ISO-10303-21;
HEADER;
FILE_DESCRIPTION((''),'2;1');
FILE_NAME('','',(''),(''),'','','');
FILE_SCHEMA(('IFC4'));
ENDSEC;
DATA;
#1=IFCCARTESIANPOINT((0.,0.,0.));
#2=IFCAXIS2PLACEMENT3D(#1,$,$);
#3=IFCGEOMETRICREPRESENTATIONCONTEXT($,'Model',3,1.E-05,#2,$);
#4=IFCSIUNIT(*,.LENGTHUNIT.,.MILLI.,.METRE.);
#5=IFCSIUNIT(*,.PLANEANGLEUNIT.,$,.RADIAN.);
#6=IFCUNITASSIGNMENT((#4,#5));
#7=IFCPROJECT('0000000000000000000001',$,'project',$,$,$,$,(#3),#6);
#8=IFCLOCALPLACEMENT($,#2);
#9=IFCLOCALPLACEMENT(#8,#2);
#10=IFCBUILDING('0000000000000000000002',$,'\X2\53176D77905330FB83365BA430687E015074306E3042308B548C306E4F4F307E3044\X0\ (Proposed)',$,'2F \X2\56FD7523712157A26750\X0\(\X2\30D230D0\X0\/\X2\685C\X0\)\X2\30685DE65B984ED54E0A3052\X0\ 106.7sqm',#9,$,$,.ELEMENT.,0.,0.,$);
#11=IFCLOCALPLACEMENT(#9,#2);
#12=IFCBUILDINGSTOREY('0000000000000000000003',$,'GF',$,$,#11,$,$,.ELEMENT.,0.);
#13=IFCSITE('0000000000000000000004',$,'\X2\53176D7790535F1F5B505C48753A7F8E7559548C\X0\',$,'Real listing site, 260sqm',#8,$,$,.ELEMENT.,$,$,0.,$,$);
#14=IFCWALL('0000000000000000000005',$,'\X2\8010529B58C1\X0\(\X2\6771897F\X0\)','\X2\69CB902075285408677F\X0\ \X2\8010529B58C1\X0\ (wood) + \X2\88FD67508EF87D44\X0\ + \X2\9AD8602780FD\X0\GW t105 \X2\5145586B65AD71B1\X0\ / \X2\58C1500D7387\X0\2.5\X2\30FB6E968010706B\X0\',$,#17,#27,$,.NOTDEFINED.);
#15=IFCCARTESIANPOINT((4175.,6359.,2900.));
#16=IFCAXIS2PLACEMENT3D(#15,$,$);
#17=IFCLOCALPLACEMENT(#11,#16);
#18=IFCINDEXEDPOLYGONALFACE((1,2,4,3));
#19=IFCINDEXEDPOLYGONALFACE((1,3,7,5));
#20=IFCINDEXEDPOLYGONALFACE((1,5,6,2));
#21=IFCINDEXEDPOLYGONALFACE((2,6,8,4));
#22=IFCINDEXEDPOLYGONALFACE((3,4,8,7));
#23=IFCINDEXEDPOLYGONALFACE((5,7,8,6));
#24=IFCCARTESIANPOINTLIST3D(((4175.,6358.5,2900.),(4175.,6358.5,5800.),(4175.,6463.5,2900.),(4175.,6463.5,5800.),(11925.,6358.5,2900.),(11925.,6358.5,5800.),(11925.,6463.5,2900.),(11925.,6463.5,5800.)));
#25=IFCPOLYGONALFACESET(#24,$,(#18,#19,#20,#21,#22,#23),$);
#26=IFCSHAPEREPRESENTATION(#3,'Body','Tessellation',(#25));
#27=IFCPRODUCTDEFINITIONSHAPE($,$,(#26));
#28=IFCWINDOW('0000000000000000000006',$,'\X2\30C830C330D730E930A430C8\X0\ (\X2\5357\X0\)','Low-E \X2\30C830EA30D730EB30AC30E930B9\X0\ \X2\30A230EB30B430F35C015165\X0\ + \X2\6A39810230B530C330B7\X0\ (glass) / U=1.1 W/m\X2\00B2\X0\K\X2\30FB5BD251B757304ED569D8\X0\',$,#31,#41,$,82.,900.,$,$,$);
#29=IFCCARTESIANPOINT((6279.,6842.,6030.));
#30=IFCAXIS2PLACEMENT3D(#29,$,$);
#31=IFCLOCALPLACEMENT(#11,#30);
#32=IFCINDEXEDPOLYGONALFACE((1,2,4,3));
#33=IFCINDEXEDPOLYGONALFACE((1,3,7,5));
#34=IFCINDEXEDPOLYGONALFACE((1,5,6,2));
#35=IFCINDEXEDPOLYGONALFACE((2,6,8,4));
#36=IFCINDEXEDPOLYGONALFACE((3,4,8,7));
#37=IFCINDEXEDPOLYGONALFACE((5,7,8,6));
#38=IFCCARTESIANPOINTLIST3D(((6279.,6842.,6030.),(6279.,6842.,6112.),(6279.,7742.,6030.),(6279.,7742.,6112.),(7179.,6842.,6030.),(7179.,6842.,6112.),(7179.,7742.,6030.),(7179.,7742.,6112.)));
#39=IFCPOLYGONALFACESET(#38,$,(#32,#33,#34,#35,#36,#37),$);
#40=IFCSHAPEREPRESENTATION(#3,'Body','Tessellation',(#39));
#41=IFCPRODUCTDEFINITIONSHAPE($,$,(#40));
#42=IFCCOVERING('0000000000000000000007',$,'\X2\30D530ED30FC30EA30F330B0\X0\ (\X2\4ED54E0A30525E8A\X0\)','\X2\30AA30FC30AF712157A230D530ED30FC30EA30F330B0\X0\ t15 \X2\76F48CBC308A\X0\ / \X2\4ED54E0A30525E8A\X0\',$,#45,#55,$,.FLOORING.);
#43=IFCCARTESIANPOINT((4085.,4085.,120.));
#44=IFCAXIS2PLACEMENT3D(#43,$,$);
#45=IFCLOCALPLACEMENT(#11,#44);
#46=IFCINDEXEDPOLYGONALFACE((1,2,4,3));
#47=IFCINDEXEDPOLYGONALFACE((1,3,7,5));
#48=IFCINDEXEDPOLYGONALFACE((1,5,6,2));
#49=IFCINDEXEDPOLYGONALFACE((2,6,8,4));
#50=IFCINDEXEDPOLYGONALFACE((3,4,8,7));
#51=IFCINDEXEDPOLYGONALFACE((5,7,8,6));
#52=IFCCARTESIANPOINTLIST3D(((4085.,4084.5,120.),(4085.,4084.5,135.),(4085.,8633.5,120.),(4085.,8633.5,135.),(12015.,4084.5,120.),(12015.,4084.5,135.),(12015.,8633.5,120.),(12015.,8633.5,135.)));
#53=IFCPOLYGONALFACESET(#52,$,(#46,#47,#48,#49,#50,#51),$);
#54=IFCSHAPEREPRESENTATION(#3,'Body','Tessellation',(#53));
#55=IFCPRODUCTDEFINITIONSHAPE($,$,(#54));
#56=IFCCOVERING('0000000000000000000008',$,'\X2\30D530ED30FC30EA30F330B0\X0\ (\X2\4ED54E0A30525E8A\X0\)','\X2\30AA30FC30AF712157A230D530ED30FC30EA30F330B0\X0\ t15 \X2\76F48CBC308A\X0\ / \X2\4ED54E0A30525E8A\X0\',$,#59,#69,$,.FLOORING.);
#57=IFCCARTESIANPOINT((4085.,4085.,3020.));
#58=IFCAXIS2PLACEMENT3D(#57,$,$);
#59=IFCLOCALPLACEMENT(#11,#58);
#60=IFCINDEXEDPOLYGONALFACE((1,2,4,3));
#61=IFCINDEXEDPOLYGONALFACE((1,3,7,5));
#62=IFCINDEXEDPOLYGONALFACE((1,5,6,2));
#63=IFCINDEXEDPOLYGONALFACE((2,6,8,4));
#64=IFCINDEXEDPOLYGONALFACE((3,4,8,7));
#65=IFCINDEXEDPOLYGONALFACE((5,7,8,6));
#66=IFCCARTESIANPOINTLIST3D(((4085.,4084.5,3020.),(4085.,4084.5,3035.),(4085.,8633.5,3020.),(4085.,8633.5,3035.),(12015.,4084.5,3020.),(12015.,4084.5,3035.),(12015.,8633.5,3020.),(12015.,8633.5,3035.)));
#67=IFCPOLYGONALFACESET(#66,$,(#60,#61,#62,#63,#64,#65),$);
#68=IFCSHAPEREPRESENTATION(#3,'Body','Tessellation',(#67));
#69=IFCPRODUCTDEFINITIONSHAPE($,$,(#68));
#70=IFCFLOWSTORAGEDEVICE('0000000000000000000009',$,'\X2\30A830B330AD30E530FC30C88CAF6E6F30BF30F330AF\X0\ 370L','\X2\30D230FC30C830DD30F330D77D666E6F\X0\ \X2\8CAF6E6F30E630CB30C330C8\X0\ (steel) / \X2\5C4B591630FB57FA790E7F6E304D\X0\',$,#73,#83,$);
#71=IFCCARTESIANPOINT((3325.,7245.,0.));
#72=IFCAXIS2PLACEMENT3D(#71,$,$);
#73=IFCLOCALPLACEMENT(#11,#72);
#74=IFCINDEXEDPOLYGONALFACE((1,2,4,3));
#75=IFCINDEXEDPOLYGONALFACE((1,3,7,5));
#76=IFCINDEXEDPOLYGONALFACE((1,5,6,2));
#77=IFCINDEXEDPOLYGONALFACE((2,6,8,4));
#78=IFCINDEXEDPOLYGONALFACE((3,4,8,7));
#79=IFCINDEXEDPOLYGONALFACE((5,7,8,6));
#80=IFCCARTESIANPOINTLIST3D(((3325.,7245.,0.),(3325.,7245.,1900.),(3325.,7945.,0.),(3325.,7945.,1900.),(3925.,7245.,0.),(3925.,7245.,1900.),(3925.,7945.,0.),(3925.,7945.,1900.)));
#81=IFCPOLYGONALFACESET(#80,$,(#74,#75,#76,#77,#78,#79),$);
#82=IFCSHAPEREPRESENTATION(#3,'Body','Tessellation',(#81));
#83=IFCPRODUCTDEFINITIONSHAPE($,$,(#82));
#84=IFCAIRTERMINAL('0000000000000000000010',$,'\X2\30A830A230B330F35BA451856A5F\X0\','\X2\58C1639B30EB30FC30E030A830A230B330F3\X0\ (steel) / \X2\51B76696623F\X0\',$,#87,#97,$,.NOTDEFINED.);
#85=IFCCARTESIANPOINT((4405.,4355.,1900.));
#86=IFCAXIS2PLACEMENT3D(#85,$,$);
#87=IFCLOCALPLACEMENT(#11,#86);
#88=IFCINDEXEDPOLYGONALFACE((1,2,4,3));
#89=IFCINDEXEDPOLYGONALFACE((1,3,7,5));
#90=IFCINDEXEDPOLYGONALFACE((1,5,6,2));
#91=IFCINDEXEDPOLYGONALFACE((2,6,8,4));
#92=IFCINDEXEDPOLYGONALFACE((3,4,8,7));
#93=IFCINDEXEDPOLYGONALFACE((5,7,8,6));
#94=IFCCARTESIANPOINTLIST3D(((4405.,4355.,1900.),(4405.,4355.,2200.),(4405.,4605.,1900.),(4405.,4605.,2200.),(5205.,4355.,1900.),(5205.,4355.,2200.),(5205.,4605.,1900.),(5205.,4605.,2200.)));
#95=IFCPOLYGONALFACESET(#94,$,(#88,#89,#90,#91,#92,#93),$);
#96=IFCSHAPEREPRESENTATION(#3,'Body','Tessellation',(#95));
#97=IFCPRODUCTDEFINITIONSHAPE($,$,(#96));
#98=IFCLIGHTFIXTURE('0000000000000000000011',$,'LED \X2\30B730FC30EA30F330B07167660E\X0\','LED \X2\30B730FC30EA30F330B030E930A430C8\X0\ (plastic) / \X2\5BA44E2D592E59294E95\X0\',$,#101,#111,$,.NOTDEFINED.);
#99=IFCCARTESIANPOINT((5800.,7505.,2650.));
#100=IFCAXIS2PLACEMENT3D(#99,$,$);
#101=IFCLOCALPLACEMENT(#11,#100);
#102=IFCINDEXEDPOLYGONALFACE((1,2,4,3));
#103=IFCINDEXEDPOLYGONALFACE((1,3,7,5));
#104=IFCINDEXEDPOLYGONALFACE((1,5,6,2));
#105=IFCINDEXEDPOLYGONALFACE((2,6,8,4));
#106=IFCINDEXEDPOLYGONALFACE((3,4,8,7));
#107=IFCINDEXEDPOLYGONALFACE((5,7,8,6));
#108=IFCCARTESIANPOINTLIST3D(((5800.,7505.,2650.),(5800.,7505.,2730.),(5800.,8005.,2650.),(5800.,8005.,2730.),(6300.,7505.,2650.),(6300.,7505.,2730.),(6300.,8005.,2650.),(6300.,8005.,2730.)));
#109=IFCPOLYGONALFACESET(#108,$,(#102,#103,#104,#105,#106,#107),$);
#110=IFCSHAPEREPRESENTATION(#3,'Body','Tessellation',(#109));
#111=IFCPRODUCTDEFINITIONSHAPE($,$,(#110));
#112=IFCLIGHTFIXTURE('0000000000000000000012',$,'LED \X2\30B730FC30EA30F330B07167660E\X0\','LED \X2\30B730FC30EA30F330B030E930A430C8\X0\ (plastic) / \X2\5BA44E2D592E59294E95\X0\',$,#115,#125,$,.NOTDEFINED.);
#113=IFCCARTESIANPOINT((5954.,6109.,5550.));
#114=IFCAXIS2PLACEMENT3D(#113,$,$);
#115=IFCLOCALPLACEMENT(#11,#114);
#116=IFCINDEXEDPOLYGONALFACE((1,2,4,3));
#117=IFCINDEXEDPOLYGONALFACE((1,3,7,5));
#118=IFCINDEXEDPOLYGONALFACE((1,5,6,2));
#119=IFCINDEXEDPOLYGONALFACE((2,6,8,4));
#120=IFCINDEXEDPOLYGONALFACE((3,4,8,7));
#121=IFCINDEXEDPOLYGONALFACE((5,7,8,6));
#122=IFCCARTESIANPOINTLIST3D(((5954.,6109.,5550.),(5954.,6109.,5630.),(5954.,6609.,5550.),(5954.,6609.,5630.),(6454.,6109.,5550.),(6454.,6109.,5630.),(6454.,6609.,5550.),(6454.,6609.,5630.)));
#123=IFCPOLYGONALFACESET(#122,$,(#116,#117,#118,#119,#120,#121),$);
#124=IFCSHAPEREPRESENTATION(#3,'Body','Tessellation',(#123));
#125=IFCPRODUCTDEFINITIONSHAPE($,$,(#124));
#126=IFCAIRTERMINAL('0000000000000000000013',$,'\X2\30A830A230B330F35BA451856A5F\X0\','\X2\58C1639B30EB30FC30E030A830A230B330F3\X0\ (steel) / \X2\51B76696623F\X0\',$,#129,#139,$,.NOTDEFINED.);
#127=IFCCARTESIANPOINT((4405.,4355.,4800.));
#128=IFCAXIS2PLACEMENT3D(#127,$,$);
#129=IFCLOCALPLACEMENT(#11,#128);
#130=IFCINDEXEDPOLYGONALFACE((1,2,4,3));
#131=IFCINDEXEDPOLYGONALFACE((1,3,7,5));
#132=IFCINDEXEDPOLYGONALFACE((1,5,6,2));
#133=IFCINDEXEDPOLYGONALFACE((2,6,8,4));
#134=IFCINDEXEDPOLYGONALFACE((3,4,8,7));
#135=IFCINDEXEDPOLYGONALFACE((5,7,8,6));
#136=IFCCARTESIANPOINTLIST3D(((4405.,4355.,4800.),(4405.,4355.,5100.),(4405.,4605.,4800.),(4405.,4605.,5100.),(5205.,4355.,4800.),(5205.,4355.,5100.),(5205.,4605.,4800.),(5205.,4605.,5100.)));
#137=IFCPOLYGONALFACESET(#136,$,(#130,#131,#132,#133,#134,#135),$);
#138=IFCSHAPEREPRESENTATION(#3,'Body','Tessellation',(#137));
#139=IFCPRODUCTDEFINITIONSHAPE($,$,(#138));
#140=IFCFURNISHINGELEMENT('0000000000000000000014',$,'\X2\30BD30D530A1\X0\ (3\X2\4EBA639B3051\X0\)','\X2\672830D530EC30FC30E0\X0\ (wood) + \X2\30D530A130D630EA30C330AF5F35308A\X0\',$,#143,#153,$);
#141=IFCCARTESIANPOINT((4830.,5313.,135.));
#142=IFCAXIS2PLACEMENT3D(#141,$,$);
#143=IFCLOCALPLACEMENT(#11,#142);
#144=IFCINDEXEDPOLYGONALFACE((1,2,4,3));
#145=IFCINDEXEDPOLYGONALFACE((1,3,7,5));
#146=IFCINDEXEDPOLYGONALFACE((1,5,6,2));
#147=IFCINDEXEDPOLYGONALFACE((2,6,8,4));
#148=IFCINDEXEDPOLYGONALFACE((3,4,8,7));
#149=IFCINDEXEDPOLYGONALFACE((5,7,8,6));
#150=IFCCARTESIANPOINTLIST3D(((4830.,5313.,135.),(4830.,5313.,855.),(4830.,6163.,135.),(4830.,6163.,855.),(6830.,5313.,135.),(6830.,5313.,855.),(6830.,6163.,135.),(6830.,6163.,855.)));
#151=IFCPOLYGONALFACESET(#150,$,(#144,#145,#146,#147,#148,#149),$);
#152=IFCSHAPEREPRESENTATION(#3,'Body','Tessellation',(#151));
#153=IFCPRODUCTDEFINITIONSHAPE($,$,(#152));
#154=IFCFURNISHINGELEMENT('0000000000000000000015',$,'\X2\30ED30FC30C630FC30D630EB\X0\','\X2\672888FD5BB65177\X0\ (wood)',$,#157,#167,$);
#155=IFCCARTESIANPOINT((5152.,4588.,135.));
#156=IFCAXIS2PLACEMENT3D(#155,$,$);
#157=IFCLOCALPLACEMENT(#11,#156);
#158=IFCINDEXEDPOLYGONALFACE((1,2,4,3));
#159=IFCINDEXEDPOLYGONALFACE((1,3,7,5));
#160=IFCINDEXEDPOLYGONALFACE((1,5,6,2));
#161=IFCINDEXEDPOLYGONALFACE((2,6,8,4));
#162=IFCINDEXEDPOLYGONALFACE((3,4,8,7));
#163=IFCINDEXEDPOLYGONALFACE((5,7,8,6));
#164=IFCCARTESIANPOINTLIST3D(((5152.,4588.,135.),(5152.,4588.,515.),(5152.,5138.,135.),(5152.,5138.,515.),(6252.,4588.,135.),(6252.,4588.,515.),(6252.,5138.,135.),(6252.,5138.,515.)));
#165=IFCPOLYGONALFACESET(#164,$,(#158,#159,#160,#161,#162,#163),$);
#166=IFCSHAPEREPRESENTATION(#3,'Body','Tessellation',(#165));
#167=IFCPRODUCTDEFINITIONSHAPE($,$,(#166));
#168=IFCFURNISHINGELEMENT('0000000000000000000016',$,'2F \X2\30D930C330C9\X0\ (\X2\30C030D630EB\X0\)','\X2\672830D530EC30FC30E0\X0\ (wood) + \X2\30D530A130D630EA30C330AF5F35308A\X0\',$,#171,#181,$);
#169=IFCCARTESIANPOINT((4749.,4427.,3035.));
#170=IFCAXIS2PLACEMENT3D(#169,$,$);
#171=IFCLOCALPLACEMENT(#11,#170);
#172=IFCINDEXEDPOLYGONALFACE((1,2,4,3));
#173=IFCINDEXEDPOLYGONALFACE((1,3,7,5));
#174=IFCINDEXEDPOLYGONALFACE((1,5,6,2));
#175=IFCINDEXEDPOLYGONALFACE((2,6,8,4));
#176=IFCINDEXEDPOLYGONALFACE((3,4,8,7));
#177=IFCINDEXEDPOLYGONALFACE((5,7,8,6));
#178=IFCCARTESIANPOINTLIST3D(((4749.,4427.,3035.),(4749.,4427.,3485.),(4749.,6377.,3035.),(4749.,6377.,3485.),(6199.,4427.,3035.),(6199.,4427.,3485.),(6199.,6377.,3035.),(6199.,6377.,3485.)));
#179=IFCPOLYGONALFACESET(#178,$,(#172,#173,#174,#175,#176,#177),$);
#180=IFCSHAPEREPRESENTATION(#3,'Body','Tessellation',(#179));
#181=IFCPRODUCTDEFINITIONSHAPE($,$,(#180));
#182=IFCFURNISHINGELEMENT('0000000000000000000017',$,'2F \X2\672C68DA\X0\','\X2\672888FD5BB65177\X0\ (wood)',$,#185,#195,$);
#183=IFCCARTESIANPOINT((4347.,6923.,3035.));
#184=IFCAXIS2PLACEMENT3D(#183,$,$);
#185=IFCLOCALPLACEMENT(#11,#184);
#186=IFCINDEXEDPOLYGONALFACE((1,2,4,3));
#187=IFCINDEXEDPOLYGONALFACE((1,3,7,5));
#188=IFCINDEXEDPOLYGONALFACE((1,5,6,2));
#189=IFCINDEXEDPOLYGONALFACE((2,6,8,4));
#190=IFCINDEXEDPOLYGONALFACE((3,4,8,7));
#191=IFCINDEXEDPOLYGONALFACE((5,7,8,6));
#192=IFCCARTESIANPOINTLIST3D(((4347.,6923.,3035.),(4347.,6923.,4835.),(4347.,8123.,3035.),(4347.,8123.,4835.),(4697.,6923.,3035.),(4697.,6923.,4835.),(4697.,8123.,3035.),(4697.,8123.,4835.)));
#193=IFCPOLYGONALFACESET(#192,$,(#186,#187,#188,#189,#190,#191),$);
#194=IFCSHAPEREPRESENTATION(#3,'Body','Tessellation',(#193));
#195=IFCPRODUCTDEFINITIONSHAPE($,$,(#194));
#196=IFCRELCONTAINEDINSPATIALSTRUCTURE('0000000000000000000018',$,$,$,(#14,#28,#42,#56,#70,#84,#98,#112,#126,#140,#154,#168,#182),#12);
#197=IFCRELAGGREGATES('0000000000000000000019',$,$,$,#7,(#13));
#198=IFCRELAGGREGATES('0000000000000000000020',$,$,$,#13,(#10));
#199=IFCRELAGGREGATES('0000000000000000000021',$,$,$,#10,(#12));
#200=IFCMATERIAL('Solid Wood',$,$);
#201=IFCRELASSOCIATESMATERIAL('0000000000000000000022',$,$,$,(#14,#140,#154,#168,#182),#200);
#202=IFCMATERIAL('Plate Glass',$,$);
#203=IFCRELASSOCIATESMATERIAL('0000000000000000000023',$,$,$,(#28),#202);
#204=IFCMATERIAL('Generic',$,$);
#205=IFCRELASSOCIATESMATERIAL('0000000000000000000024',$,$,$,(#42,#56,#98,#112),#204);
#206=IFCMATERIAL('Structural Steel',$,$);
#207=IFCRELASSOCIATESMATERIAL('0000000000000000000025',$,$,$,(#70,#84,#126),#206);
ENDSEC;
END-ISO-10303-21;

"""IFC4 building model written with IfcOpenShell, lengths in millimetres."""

from ifc_helpers import new_model, si_unit, frame, frame_2d, origin, place, context, project, spatial, rectangle, extrude, material, element, save


model = new_model("IFC4")

# Units and contexts
model_context = context("Model", 3, precision=1e-05, world=origin())
ifc_project = project(units=[si_unit("LENGTHUNIT", "METRE", prefix="MILLI"), si_unit("PLANEANGLEUNIT", "RADIAN")], contexts=[model_context])

# Site, building, storey
site_placement = place(None, origin())
site = spatial("IfcSite", under=ifc_project, at=site_placement, Name="北海道弟子屈町美留和", ObjectType="Real listing site, 260sqm", CompositionType="ELEMENT", RefElevation=0.0)
building_placement = place(site_placement, origin())
building = spatial("IfcBuilding", under=site, at=building_placement, Name="北海道・茶室と縁側のある和の住まい (Proposed)", ObjectType="2F 国産無垢材(ヒバ/桜)と左官仕上げ 106.7sqm", CompositionType="ELEMENT", ElevationOfRefHeight=0.0, ElevationOfTerrain=0.0)
storey_placement = place(building_placement, origin())
storey = spatial("IfcBuildingStorey", under=building, at=storey_placement, Name="GF", CompositionType="ELEMENT", Elevation=0.0)

# Shared definitions
ifc_material_1 = material(Name="Solid Wood")

# Wall
wall_1_placement = place(storey_placement, frame((4175.0, 6359.0, 2900.0)))
element("IfcWall", 1, at=wall_1_placement, inside=storey, material=ifc_material_1, Name="耐力壁(東西)", Description="構造用合板 耐力壁 (wood) + 製材軸組 + 高性能GW t105 充填断熱 / 壁倍率2.5・準耐火", PredefinedType="NOTDEFINED", context=model_context, shape_type="SweptSolid", body=[
    extrude(rectangle(XDim=7750.0, YDim=105.0, at=frame_2d((3875.0, 52.0))), frame((4175.0, 6359.0, 2900.0)), (0.0, 0.0, 1.0), 2900.0),
])

# Window
ifc_material_2 = material(Name="Plate Glass")
window_placement = place(storey_placement, frame((6279.0, 6842.0, 6030.0)))
element("IfcWindow", 2, at=window_placement, inside=storey, material=ifc_material_2, Name="トップライト (南)", Description="Low-E トリプルガラス アルゴン封入 + 樹脂サッシ (glass) / U=1.1 W/m²K・寒冷地仕様", OverallHeight=82.0, OverallWidth=900.0, context=model_context, shape_type="SweptSolid", body=[
    extrude(rectangle(XDim=900.0, YDim=900.0, at=frame_2d((450.0, 450.0))), frame((6279.0, 6842.0, 6030.0)), (0.0, 0.0, 1.0), 82.0),
])

# Coverings
ifc_material_3 = material(Name="Generic")
covering_1_placement = place(storey_placement, frame((4085.0, 4085.0, 120.0)))
element("IfcCovering", 3, at=covering_1_placement, inside=storey, material=ifc_material_3, Name="フローリング (仕上げ床)", Description="オーク無垢フローリング t15 直貼り / 仕上げ床", PredefinedType="FLOORING", context=model_context, shape_type="SweptSolid", body=[
    extrude(rectangle(XDim=7930.0, YDim=4549.0, at=frame_2d((3965.0, 2274.0))), frame((4085.0, 4085.0, 120.0)), (0.0, 0.0, 1.0), 15.0),
])
covering_2_placement = place(storey_placement, frame((4085.0, 4085.0, 3020.0)))
element("IfcCovering", 4, at=covering_2_placement, inside=storey, material=ifc_material_3, Name="フローリング (仕上げ床)", Description="オーク無垢フローリング t15 直貼り / 仕上げ床", PredefinedType="FLOORING", context=model_context, shape_type="SweptSolid", body=[
    extrude(rectangle(XDim=7930.0, YDim=4549.0, at=frame_2d((3965.0, 2274.0))), frame((4085.0, 4085.0, 3020.0)), (0.0, 0.0, 1.0), 15.0),
])

# Flow storage device
ifc_material_4 = material(Name="Structural Steel")
flow_storage_device_placement = place(storey_placement, frame((3325.0, 7245.0, 0.0)))
element("IfcFlowStorageDevice", 5, at=flow_storage_device_placement, inside=storey, material=ifc_material_4, Name="エコキュート貯湯タンク 370L", Description="ヒートポンプ給湯 貯湯ユニット (steel) / 屋外・基礎置き", context=model_context, shape_type="SweptSolid", body=[
    extrude(rectangle(XDim=600.0, YDim=700.0, at=frame_2d((300.0, 350.0))), frame((3325.0, 7245.0, 0.0)), (0.0, 0.0, 1.0), 1900.0),
])

# Air terminal
air_terminal_1_placement = place(storey_placement, frame((4405.0, 4355.0, 1900.0)))
element("IfcAirTerminal", 6, at=air_terminal_1_placement, inside=storey, material=ifc_material_4, Name="エアコン室内機", Description="壁掛ルームエアコン (steel) / 冷暖房", PredefinedType="NOTDEFINED", context=model_context, shape_type="SweptSolid", body=[
    extrude(rectangle(XDim=800.0, YDim=250.0, at=frame_2d((400.0, 125.0))), frame((4405.0, 4355.0, 1900.0)), (0.0, 0.0, 1.0), 300.0),
])

# Light fixtures
light_fixture_1_placement = place(storey_placement, frame((5800.0, 7505.0, 2650.0)))
element("IfcLightFixture", 7, at=light_fixture_1_placement, inside=storey, material=ifc_material_3, Name="LED シーリング照明", Description="LED シーリングライト (plastic) / 室中央天井", PredefinedType="NOTDEFINED", context=model_context, shape_type="SweptSolid", body=[
    extrude(rectangle(XDim=500.0, YDim=500.0, at=frame_2d((250.0, 250.0))), frame((5800.0, 7505.0, 2650.0)), (0.0, 0.0, 1.0), 80.0),
])
light_fixture_2_placement = place(storey_placement, frame((5954.0, 6109.0, 5550.0)))
element("IfcLightFixture", 8, at=light_fixture_2_placement, inside=storey, material=ifc_material_3, Name="LED シーリング照明", Description="LED シーリングライト (plastic) / 室中央天井", PredefinedType="NOTDEFINED", context=model_context, shape_type="SweptSolid", body=[
    extrude(rectangle(XDim=500.0, YDim=500.0, at=frame_2d((250.0, 250.0))), frame((5954.0, 6109.0, 5550.0)), (0.0, 0.0, 1.0), 80.0),
])

# Air terminal
air_terminal_2_placement = place(storey_placement, frame((4405.0, 4355.0, 4800.0)))
element("IfcAirTerminal", 9, at=air_terminal_2_placement, inside=storey, material=ifc_material_4, Name="エアコン室内機", Description="壁掛ルームエアコン (steel) / 冷暖房", PredefinedType="NOTDEFINED", context=model_context, shape_type="SweptSolid", body=[
    extrude(rectangle(XDim=800.0, YDim=250.0, at=frame_2d((400.0, 125.0))), frame((4405.0, 4355.0, 4800.0)), (0.0, 0.0, 1.0), 300.0),
])

# Furnishing elements
furnishing_1_placement = place(storey_placement, frame((4830.0, 5313.0, 135.0)))
element("IfcFurnishingElement", 10, at=furnishing_1_placement, inside=storey, material=ifc_material_1, Name="ソファ (3人掛け)", Description="木フレーム (wood) + ファブリック張り", context=model_context, shape_type="SweptSolid", body=[
    extrude(rectangle(XDim=2000.0, YDim=850.0, at=frame_2d((1000.0, 425.0))), frame((4830.0, 5313.0, 135.0)), (0.0, 0.0, 1.0), 720.0),
])
furnishing_2_placement = place(storey_placement, frame((5152.0, 4588.0, 135.0)))
element("IfcFurnishingElement", 11, at=furnishing_2_placement, inside=storey, material=ifc_material_1, Name="ローテーブル", Description="木製家具 (wood)", context=model_context, shape_type="SweptSolid", body=[
    extrude(rectangle(XDim=1100.0, YDim=550.0, at=frame_2d((550.0, 275.0))), frame((5152.0, 4588.0, 135.0)), (0.0, 0.0, 1.0), 380.0),
])
furnishing_3_placement = place(storey_placement, frame((4749.0, 4427.0, 3035.0)))
element("IfcFurnishingElement", 12, at=furnishing_3_placement, inside=storey, material=ifc_material_1, Name="2F ベッド (ダブル)", Description="木フレーム (wood) + ファブリック張り", context=model_context, shape_type="SweptSolid", body=[
    extrude(rectangle(XDim=1450.0, YDim=1950.0, at=frame_2d((725.0, 975.0))), frame((4749.0, 4427.0, 3035.0)), (0.0, 0.0, 1.0), 450.0),
])
furnishing_4_placement = place(storey_placement, frame((4347.0, 6923.0, 3035.0)))
element("IfcFurnishingElement", 13, at=furnishing_4_placement, inside=storey, material=ifc_material_1, Name="2F 本棚", Description="木製家具 (wood)", context=model_context, shape_type="SweptSolid", body=[
    extrude(rectangle(XDim=350.0, YDim=1200.0, at=frame_2d((175.0, 600.0))), frame((4347.0, 6923.0, 3035.0)), (0.0, 0.0, 1.0), 1800.0),
])

save(model, "model.ifc")
